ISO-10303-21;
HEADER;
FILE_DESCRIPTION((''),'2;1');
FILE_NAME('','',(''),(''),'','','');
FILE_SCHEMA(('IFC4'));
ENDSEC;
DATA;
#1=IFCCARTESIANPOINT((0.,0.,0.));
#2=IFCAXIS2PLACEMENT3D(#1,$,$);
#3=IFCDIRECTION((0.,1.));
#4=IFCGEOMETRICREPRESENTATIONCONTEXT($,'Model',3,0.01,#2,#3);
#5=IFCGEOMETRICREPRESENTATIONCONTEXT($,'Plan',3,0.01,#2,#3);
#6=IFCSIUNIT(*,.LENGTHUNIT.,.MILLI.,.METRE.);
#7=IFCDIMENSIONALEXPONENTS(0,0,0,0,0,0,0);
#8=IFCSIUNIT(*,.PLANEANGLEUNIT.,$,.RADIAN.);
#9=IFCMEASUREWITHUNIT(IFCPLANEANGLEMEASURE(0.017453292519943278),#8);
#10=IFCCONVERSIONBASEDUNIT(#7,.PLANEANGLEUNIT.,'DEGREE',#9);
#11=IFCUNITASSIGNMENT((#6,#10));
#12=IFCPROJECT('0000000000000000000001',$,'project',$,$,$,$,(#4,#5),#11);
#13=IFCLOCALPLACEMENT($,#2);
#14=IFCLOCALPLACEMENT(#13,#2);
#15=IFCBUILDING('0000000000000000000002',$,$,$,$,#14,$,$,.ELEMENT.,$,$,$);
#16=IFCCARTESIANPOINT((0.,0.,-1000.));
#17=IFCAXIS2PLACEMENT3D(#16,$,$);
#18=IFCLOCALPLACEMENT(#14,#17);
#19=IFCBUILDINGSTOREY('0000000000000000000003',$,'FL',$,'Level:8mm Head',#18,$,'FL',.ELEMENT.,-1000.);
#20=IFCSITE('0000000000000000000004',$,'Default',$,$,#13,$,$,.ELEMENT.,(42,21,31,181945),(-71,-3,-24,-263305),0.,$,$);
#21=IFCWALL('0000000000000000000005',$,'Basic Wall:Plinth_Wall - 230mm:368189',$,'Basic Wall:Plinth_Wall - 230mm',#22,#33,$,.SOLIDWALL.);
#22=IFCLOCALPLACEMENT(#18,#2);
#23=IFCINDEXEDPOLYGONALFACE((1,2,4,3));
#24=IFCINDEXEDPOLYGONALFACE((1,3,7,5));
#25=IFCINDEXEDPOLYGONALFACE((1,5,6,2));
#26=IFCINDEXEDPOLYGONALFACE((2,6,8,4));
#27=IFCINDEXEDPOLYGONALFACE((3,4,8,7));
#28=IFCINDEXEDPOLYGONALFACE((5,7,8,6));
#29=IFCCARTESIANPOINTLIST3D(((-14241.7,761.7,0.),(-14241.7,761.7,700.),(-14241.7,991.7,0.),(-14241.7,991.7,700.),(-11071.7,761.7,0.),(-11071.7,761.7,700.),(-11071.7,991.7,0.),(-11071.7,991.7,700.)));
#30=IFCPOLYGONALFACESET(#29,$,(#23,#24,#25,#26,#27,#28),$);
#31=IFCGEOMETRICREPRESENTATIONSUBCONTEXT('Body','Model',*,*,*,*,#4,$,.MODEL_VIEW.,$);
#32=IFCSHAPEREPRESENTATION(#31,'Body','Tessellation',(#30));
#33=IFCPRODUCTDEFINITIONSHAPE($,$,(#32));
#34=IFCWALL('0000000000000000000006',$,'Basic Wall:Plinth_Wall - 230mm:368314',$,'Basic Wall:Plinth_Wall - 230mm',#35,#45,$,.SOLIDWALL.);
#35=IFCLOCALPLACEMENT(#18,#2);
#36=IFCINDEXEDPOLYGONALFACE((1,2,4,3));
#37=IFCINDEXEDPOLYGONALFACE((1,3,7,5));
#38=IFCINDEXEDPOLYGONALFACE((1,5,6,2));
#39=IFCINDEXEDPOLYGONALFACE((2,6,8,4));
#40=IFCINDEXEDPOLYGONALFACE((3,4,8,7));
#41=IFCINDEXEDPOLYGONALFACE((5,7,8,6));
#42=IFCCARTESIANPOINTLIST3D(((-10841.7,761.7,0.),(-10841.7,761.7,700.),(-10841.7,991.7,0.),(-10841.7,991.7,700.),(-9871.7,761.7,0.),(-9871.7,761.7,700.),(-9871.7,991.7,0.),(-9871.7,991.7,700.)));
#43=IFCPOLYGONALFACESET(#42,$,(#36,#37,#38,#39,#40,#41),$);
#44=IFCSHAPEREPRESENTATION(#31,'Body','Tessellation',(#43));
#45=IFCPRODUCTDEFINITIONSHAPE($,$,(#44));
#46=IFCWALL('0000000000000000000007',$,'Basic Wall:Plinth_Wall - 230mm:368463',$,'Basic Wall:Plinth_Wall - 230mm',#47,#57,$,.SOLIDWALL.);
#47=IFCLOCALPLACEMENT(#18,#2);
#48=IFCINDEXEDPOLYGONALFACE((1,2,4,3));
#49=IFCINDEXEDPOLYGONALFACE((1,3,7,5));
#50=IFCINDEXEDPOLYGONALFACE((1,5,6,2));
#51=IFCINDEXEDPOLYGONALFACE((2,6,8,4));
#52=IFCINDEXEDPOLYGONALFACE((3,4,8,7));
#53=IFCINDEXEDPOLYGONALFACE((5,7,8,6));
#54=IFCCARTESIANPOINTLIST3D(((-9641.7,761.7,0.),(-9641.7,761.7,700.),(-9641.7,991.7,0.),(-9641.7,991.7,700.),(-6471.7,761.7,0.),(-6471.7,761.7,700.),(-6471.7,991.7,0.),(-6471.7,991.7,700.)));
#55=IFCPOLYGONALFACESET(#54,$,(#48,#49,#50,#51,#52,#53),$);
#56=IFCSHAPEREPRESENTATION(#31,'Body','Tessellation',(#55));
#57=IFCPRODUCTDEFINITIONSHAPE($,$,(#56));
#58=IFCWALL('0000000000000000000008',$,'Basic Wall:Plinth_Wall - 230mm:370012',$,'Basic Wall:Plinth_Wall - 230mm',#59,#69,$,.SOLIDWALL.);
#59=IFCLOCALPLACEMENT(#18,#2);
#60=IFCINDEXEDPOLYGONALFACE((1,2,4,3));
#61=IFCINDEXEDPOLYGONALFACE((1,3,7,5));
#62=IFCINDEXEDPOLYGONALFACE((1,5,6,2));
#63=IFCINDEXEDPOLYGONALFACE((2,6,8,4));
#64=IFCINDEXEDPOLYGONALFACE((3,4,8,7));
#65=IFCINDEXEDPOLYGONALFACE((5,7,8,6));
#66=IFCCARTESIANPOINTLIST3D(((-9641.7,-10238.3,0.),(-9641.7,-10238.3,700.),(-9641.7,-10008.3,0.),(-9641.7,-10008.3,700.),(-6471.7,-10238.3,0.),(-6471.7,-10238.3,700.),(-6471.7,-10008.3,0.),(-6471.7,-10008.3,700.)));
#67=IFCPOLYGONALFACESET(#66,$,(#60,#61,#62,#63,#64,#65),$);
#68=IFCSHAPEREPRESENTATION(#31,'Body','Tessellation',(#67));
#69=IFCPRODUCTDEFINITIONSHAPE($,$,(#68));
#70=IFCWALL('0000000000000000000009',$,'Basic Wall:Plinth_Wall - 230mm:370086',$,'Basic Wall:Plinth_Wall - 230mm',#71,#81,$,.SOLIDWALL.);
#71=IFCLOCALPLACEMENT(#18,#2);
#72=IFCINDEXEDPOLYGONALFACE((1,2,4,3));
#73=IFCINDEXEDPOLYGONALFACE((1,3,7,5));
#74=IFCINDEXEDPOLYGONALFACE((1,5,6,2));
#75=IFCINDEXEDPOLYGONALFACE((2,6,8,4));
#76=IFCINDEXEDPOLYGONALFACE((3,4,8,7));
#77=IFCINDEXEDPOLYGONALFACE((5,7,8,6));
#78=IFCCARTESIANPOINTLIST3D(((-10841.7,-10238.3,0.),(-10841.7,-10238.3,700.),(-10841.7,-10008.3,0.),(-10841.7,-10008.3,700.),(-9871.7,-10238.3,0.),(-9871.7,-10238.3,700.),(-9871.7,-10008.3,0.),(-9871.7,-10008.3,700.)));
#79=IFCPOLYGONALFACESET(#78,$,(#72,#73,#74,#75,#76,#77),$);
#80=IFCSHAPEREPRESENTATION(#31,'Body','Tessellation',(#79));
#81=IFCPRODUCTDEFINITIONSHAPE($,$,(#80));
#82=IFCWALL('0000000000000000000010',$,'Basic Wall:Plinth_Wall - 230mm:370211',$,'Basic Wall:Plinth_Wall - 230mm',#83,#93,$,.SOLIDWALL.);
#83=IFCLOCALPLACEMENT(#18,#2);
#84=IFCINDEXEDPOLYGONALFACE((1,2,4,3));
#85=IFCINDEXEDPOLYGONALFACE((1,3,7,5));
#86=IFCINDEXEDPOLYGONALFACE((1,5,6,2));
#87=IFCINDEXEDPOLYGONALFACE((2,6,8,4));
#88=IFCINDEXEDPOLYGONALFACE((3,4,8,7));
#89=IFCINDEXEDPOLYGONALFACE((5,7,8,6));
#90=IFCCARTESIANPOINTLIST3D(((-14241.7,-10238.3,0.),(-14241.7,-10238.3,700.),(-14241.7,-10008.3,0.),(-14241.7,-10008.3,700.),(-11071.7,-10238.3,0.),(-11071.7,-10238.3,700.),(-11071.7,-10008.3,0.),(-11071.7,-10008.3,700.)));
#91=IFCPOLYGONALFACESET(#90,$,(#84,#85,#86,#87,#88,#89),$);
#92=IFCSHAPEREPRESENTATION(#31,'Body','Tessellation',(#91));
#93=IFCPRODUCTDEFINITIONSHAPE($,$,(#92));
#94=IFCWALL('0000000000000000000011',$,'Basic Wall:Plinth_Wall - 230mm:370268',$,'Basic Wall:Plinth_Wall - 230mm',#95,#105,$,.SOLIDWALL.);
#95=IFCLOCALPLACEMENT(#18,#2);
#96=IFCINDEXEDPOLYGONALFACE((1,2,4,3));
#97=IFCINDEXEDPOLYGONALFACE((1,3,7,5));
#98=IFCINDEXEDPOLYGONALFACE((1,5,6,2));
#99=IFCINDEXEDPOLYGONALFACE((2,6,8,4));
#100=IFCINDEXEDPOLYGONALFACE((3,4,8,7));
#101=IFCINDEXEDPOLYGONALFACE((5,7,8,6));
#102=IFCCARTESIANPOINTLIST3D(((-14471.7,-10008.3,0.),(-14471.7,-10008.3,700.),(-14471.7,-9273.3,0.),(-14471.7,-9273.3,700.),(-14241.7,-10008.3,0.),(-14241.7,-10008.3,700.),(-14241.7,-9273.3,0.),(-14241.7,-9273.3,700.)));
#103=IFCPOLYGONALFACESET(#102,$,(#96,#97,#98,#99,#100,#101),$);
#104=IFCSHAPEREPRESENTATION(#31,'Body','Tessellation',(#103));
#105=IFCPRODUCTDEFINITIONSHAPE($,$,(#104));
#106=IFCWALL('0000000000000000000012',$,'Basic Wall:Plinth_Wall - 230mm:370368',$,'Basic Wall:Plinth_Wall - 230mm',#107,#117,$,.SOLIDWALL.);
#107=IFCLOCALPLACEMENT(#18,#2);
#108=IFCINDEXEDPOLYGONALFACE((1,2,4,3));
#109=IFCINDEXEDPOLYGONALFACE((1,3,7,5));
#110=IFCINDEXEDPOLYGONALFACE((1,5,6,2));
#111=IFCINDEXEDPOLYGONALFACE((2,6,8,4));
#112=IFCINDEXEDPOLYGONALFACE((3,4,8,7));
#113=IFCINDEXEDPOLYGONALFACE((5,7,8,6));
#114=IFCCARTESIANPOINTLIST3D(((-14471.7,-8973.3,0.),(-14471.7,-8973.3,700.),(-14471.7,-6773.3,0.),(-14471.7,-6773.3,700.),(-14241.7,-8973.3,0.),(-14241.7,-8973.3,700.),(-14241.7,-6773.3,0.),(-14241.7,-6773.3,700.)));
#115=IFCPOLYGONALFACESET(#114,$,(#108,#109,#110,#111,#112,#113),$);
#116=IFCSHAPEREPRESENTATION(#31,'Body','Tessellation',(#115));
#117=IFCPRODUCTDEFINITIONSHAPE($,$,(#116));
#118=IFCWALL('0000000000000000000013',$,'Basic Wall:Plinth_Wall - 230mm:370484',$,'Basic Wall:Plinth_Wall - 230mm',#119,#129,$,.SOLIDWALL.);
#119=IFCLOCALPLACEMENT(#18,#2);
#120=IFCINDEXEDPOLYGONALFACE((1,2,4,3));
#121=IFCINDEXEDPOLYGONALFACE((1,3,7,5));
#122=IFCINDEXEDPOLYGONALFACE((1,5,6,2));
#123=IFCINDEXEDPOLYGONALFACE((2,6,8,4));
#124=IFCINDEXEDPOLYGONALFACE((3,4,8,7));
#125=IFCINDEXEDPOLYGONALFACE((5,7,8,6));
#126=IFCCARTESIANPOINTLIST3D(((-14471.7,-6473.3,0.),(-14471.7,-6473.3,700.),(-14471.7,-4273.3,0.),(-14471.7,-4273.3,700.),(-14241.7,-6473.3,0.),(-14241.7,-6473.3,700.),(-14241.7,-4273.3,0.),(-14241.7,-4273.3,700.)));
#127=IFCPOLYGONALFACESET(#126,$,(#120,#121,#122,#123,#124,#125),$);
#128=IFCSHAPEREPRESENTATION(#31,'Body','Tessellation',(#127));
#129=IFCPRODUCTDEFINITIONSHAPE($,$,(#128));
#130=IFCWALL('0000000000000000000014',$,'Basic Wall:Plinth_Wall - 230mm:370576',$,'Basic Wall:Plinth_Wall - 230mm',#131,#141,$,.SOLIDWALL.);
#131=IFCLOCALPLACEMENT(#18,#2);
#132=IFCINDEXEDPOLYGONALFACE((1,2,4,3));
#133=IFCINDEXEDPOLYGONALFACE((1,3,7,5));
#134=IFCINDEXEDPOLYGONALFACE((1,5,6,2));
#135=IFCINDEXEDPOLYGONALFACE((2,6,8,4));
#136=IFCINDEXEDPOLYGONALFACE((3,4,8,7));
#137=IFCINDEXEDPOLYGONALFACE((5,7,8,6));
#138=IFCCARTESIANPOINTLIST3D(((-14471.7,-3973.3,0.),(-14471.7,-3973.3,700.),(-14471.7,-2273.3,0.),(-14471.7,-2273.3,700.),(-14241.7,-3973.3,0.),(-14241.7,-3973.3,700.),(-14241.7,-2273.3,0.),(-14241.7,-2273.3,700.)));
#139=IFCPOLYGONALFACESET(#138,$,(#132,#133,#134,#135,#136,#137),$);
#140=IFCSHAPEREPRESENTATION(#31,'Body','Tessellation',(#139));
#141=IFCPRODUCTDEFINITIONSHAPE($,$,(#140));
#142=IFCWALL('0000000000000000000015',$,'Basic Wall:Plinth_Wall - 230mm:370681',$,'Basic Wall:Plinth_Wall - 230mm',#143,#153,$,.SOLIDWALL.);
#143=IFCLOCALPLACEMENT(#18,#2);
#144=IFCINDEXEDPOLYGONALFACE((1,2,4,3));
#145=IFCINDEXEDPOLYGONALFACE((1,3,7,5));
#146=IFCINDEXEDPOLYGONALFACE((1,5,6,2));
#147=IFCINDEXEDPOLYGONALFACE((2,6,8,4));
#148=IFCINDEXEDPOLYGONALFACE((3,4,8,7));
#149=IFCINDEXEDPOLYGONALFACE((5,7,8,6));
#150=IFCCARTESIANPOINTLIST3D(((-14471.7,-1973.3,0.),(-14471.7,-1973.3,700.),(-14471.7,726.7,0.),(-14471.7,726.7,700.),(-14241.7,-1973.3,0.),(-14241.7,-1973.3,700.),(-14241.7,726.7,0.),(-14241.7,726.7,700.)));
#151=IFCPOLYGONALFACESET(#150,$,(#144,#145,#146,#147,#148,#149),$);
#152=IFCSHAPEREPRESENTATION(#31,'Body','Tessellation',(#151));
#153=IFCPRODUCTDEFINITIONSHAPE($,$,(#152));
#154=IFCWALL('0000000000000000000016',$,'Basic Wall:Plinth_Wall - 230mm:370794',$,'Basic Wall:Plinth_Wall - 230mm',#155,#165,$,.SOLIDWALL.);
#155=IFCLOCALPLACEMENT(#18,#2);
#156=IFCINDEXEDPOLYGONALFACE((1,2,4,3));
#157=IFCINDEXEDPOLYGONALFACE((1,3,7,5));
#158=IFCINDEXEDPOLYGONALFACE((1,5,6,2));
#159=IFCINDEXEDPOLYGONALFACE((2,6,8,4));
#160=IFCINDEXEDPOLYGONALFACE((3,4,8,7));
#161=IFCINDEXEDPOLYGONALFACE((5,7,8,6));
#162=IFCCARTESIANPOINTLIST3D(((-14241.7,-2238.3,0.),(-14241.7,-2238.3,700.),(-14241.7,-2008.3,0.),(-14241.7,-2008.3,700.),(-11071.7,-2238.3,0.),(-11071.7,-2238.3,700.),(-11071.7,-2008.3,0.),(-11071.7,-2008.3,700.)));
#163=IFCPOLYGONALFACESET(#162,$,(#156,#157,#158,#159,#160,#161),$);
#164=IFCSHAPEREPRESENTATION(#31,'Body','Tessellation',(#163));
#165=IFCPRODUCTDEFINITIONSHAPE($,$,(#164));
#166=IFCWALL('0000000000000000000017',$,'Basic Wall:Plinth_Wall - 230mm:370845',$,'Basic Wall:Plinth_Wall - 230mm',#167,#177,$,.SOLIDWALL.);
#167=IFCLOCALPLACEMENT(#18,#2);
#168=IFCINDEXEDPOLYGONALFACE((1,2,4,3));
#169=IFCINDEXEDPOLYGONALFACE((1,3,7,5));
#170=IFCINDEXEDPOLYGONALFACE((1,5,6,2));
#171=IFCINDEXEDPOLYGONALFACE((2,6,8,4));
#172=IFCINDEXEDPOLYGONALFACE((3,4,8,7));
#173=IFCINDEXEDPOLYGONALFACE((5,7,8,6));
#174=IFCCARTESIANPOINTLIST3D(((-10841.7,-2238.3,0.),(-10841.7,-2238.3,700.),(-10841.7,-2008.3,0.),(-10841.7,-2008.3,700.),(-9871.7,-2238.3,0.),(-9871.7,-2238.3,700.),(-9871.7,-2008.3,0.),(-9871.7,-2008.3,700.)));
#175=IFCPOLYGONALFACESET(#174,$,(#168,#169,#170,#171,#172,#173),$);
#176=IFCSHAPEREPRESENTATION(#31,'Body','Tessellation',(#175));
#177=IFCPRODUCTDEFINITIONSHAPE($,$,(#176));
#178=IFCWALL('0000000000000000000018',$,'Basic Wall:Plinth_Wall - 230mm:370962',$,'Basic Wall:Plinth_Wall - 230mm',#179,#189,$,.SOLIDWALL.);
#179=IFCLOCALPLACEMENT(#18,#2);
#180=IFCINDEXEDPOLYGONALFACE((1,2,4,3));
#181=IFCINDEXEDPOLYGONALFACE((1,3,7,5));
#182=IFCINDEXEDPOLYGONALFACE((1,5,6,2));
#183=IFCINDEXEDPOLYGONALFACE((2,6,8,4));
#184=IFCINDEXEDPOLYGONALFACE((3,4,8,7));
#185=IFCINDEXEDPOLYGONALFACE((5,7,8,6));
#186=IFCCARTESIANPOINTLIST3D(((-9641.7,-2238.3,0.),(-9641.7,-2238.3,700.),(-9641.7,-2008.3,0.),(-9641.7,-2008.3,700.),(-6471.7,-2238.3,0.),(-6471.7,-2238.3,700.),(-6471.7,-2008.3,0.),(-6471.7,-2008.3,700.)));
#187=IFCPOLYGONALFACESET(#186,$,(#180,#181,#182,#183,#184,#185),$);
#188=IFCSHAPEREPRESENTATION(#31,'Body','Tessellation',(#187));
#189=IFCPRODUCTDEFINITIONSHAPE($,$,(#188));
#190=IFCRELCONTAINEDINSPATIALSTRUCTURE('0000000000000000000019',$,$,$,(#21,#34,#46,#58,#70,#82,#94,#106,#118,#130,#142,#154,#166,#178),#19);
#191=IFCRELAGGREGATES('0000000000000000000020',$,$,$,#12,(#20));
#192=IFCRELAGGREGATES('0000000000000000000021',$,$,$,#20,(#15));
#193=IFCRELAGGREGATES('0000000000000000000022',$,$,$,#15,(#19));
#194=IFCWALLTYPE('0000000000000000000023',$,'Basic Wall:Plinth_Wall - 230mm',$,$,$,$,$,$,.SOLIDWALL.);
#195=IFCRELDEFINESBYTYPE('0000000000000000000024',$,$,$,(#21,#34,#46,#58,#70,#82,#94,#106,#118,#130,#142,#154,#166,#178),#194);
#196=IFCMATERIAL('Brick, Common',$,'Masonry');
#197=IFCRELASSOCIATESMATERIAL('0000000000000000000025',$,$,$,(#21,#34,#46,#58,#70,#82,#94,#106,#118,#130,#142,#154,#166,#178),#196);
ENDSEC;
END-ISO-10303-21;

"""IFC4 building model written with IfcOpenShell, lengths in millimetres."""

from ifc_helpers import new_model, entity, si_unit, converted_unit, direction, frame, origin, place, context, subcontext, project, spatial, indexed_curve, outline, extrude, material, type_object, element, save


model = new_model("IFC4")

# Units and contexts
model_context = context("Model", 3, precision=0.01, world=origin(), true_north=direction((0.0, 1.0)))
plan_context = context("Plan", 3, precision=0.01, world=origin(), true_north=direction((0.0, 1.0)))
body_context = subcontext(model_context, "Body", "Model", "MODEL_VIEW")
ifc_project = project(units=[si_unit("LENGTHUNIT", "METRE", prefix="MILLI"), converted_unit("PLANEANGLEUNIT", "DEGREE", entity("IfcPlaneAngleMeasure", 0.017453292519943278), si_unit("PLANEANGLEUNIT", "RADIAN"), dimensions=[0, 0, 0, 0, 0, 0, 0])], contexts=[model_context, plan_context])

# Site, building, storey
site_placement = place(None, origin())
site = spatial("IfcSite", under=ifc_project, at=site_placement, Name="Default", CompositionType="ELEMENT", RefLatitude=(42, 21, 31, 181945), RefLongitude=(-71, -3, -24, -263305), RefElevation=0.0)
building_placement = place(site_placement, origin())
building = spatial("IfcBuilding", under=site, at=building_placement, CompositionType="ELEMENT")
storey_placement = place(building_placement, frame((0.0, 0.0, -1000.0)))
storey = spatial("IfcBuildingStorey", under=building, at=storey_placement, Name="FL", ObjectType="Level:8mm Head", LongName="FL", CompositionType="ELEMENT", Elevation=-1000.0)

# Walls
ifc_material = material(Name="Brick, Common", Category="Masonry")
wall_type = type_object("IfcWallType", Name="Basic Wall:Plinth_Wall - 230mm", PredefinedType="SOLIDWALL")
wall_1_placement = place(storey_placement, frame((-14241.7, 876.7, 0.0)))
element("IfcWall", 1, at=wall_1_placement, inside=storey, type_object=wall_type, material=ifc_material, Name="Basic Wall:Plinth_Wall - 230mm:368189", ObjectType="Basic Wall:Plinth_Wall - 230mm", PredefinedType="SOLIDWALL", context=body_context, shape_type="SweptSolid", body=[
    extrude(outline(indexed_curve([(3170.0, 115.0), (0.0, 115.0), (0.0, -115.0), (3170.0, -115.0), (3170.0, 115.0)], self_intersect=False)), origin(), (0.0, 0.0, 1.0), 700.0),
])
wall_2_placement = place(storey_placement, frame((-10841.7, 876.7, 0.0)))
element("IfcWall", 2, at=wall_2_placement, inside=storey, type_object=wall_type, material=ifc_material, Name="Basic Wall:Plinth_Wall - 230mm:368314", ObjectType="Basic Wall:Plinth_Wall - 230mm", PredefinedType="SOLIDWALL", context=body_context, shape_type="SweptSolid", body=[
    extrude(outline(indexed_curve([(970.0, 115.0), (0.0, 115.0), (0.0, -115.0), (970.0, -115.0), (970.0, 115.0)], self_intersect=False)), origin(), (0.0, 0.0, 1.0), 700.0),
])
wall_3_placement = place(storey_placement, frame((-9641.7, 876.7, 0.0)))
element("IfcWall", 3, at=wall_3_placement, inside=storey, type_object=wall_type, material=ifc_material, Name="Basic Wall:Plinth_Wall - 230mm:368463", ObjectType="Basic Wall:Plinth_Wall - 230mm", PredefinedType="SOLIDWALL", context=body_context, shape_type="SweptSolid", body=[
    extrude(outline(indexed_curve([(3170.0, 115.0), (0.0, 115.0), (0.0, -115.0), (3170.0, -115.0), (3170.0, 115.0)], self_intersect=False)), origin(), (0.0, 0.0, 1.0), 700.0),
])
wall_4_placement = place(storey_placement, frame((-6471.7, -10123.3, 0.0), z_axis=(0.0, 0.0, 1.0), x_axis=(-1.0, 0.0, 0.0)))
element("IfcWall", 4, at=wall_4_placement, inside=storey, type_object=wall_type, material=ifc_material, Name="Basic Wall:Plinth_Wall - 230mm:370012", ObjectType="Basic Wall:Plinth_Wall - 230mm", PredefinedType="SOLIDWALL", context=body_context, shape_type="SweptSolid", body=[
    extrude(outline(indexed_curve([(3170.0, 115.0), (0.0, 115.0), (0.0, -115.0), (3170.0, -115.0), (3170.0, 115.0)], self_intersect=False)), origin(), (0.0, 0.0, 1.0), 700.0),
])
wall_5_placement = place(storey_placement, frame((-9871.7, -10123.3, 0.0), z_axis=(0.0, 0.0, 1.0), x_axis=(-1.0, 0.0, 0.0)))
element("IfcWall", 5, at=wall_5_placement, inside=storey, type_object=wall_type, material=ifc_material, Name="Basic Wall:Plinth_Wall - 230mm:370086", ObjectType="Basic Wall:Plinth_Wall - 230mm", PredefinedType="SOLIDWALL", context=body_context, shape_type="SweptSolid", body=[
    extrude(outline(indexed_curve([(970.0, 115.0), (0.0, 115.0), (0.0, -115.0), (970.0, -115.0), (970.0, 115.0)], self_intersect=False)), origin(), (0.0, 0.0, 1.0), 700.0),
])
wall_6_placement = place(storey_placement, frame((-11071.7, -10123.3, 0.0), z_axis=(0.0, 0.0, 1.0), x_axis=(-1.0, 0.0, 0.0)))
element("IfcWall", 6, at=wall_6_placement, inside=storey, type_object=wall_type, material=ifc_material, Name="Basic Wall:Plinth_Wall - 230mm:370211", ObjectType="Basic Wall:Plinth_Wall - 230mm", PredefinedType="SOLIDWALL", context=body_context, shape_type="SweptSolid", body=[
    extrude(outline(indexed_curve([(3170.0, 115.0), (0.0, 115.0), (0.0, -115.0), (3170.0, -115.0), (3170.0, 115.0)], self_intersect=False)), origin(), (0.0, 0.0, 1.0), 700.0),
])
wall_7_placement = place(storey_placement, frame((-14356.7, -10008.3, 0.0), z_axis=(0.0, 0.0, 1.0), x_axis=(0.0, 1.0, 0.0)))
element("IfcWall", 7, at=wall_7_placement, inside=storey, type_object=wall_type, material=ifc_material, Name="Basic Wall:Plinth_Wall - 230mm:370268", ObjectType="Basic Wall:Plinth_Wall - 230mm", PredefinedType="SOLIDWALL", context=body_context, shape_type="SweptSolid", body=[
    extrude(outline(indexed_curve([(735.0, 115.0), (0.0, 115.0), (0.0, -115.0), (735.0, -115.0), (735.0, 115.0)], self_intersect=False)), origin(), (0.0, 0.0, 1.0), 700.0),
])
for number, where, z_axis, x_axis, name in (
    (8, (-14356.7, -8973.3, 0.0), (0.0, 0.0, 1.0), (0.0, 1.0, 0.0), "Basic Wall:Plinth_Wall - 230mm:370368"),
    (9, (-14356.7, -6473.3, 0.0), (0.0, 0.0, 1.0), (0.0, 1.0, 0.0), "Basic Wall:Plinth_Wall - 230mm:370484"),
):
    element("IfcWall", number, at=place(storey_placement, frame(where, z_axis=z_axis, x_axis=x_axis)), inside=storey, type_object=wall_type, material=ifc_material, Name=name, ObjectType="Basic Wall:Plinth_Wall - 230mm", PredefinedType="SOLIDWALL", context=body_context, shape_type="SweptSolid", body=[
        extrude(outline(indexed_curve([(2200.0, 115.0), (0.0, 115.0), (0.0, -115.0), (2200.0, -115.0), (2200.0, 115.0)], self_intersect=False)), origin(), (0.0, 0.0, 1.0), 700.0),
    ])
wall_8_placement = place(storey_placement, frame((-14356.7, -3973.3, 0.0), z_axis=(0.0, 0.0, 1.0), x_axis=(0.0, 1.0, 0.0)))
element("IfcWall", 10, at=wall_8_placement, inside=storey, type_object=wall_type, material=ifc_material, Name="Basic Wall:Plinth_Wall - 230mm:370576", ObjectType="Basic Wall:Plinth_Wall - 230mm", PredefinedType="SOLIDWALL", context=body_context, shape_type="SweptSolid", body=[
    extrude(outline(indexed_curve([(1700.0, 115.0), (0.0, 115.0), (0.0, -115.0), (1700.0, -115.0), (1700.0, 115.0)], self_intersect=False)), origin(), (0.0, 0.0, 1.0), 700.0),
])
wall_9_placement = place(storey_placement, frame((-14356.7, -1973.3, 0.0), z_axis=(0.0, 0.0, 1.0), x_axis=(0.0, 1.0, 0.0)))
element("IfcWall", 11, at=wall_9_placement, inside=storey, type_object=wall_type, material=ifc_material, Name="Basic Wall:Plinth_Wall - 230mm:370681", ObjectType="Basic Wall:Plinth_Wall - 230mm", PredefinedType="SOLIDWALL", context=body_context, shape_type="SweptSolid", body=[
    extrude(outline(indexed_curve([(2700.0, 115.0), (0.0, 115.0), (0.0, -115.0), (2700.0, -115.0), (2700.0, 115.0)], self_intersect=False)), origin(), (0.0, 0.0, 1.0), 700.0),
])
wall_10_placement = place(storey_placement, frame((-14241.7, -2123.3, 0.0)))
element("IfcWall", 12, at=wall_10_placement, inside=storey, type_object=wall_type, material=ifc_material, Name="Basic Wall:Plinth_Wall - 230mm:370794", ObjectType="Basic Wall:Plinth_Wall - 230mm", PredefinedType="SOLIDWALL", context=body_context, shape_type="SweptSolid", body=[
    extrude(outline(indexed_curve([(3170.0, 115.0), (0.0, 115.0), (0.0, -115.0), (3170.0, -115.0), (3170.0, 115.0)], self_intersect=False)), origin(), (0.0, 0.0, 1.0), 700.0),
])
wall_11_placement = place(storey_placement, frame((-10841.7, -2123.3, 0.0)))
element("IfcWall", 13, at=wall_11_placement, inside=storey, type_object=wall_type, material=ifc_material, Name="Basic Wall:Plinth_Wall - 230mm:370845", ObjectType="Basic Wall:Plinth_Wall - 230mm", PredefinedType="SOLIDWALL", context=body_context, shape_type="SweptSolid", body=[
    extrude(outline(indexed_curve([(970.0, 115.0), (0.0, 115.0), (0.0, -115.0), (970.0, -115.0), (970.0, 115.0)], self_intersect=False)), origin(), (0.0, 0.0, 1.0), 700.0),
])
wall_12_placement = place(storey_placement, frame((-9641.7, -2123.3, 0.0)))
element("IfcWall", 14, at=wall_12_placement, inside=storey, type_object=wall_type, material=ifc_material, Name="Basic Wall:Plinth_Wall - 230mm:370962", ObjectType="Basic Wall:Plinth_Wall - 230mm", PredefinedType="SOLIDWALL", context=body_context, shape_type="SweptSolid", body=[
    extrude(outline(indexed_curve([(3170.0, 115.0), (0.0, 115.0), (0.0, -115.0), (3170.0, -115.0), (3170.0, 115.0)], self_intersect=False)), origin(), (0.0, 0.0, 1.0), 700.0),
])

save(model, "model.ifc")
